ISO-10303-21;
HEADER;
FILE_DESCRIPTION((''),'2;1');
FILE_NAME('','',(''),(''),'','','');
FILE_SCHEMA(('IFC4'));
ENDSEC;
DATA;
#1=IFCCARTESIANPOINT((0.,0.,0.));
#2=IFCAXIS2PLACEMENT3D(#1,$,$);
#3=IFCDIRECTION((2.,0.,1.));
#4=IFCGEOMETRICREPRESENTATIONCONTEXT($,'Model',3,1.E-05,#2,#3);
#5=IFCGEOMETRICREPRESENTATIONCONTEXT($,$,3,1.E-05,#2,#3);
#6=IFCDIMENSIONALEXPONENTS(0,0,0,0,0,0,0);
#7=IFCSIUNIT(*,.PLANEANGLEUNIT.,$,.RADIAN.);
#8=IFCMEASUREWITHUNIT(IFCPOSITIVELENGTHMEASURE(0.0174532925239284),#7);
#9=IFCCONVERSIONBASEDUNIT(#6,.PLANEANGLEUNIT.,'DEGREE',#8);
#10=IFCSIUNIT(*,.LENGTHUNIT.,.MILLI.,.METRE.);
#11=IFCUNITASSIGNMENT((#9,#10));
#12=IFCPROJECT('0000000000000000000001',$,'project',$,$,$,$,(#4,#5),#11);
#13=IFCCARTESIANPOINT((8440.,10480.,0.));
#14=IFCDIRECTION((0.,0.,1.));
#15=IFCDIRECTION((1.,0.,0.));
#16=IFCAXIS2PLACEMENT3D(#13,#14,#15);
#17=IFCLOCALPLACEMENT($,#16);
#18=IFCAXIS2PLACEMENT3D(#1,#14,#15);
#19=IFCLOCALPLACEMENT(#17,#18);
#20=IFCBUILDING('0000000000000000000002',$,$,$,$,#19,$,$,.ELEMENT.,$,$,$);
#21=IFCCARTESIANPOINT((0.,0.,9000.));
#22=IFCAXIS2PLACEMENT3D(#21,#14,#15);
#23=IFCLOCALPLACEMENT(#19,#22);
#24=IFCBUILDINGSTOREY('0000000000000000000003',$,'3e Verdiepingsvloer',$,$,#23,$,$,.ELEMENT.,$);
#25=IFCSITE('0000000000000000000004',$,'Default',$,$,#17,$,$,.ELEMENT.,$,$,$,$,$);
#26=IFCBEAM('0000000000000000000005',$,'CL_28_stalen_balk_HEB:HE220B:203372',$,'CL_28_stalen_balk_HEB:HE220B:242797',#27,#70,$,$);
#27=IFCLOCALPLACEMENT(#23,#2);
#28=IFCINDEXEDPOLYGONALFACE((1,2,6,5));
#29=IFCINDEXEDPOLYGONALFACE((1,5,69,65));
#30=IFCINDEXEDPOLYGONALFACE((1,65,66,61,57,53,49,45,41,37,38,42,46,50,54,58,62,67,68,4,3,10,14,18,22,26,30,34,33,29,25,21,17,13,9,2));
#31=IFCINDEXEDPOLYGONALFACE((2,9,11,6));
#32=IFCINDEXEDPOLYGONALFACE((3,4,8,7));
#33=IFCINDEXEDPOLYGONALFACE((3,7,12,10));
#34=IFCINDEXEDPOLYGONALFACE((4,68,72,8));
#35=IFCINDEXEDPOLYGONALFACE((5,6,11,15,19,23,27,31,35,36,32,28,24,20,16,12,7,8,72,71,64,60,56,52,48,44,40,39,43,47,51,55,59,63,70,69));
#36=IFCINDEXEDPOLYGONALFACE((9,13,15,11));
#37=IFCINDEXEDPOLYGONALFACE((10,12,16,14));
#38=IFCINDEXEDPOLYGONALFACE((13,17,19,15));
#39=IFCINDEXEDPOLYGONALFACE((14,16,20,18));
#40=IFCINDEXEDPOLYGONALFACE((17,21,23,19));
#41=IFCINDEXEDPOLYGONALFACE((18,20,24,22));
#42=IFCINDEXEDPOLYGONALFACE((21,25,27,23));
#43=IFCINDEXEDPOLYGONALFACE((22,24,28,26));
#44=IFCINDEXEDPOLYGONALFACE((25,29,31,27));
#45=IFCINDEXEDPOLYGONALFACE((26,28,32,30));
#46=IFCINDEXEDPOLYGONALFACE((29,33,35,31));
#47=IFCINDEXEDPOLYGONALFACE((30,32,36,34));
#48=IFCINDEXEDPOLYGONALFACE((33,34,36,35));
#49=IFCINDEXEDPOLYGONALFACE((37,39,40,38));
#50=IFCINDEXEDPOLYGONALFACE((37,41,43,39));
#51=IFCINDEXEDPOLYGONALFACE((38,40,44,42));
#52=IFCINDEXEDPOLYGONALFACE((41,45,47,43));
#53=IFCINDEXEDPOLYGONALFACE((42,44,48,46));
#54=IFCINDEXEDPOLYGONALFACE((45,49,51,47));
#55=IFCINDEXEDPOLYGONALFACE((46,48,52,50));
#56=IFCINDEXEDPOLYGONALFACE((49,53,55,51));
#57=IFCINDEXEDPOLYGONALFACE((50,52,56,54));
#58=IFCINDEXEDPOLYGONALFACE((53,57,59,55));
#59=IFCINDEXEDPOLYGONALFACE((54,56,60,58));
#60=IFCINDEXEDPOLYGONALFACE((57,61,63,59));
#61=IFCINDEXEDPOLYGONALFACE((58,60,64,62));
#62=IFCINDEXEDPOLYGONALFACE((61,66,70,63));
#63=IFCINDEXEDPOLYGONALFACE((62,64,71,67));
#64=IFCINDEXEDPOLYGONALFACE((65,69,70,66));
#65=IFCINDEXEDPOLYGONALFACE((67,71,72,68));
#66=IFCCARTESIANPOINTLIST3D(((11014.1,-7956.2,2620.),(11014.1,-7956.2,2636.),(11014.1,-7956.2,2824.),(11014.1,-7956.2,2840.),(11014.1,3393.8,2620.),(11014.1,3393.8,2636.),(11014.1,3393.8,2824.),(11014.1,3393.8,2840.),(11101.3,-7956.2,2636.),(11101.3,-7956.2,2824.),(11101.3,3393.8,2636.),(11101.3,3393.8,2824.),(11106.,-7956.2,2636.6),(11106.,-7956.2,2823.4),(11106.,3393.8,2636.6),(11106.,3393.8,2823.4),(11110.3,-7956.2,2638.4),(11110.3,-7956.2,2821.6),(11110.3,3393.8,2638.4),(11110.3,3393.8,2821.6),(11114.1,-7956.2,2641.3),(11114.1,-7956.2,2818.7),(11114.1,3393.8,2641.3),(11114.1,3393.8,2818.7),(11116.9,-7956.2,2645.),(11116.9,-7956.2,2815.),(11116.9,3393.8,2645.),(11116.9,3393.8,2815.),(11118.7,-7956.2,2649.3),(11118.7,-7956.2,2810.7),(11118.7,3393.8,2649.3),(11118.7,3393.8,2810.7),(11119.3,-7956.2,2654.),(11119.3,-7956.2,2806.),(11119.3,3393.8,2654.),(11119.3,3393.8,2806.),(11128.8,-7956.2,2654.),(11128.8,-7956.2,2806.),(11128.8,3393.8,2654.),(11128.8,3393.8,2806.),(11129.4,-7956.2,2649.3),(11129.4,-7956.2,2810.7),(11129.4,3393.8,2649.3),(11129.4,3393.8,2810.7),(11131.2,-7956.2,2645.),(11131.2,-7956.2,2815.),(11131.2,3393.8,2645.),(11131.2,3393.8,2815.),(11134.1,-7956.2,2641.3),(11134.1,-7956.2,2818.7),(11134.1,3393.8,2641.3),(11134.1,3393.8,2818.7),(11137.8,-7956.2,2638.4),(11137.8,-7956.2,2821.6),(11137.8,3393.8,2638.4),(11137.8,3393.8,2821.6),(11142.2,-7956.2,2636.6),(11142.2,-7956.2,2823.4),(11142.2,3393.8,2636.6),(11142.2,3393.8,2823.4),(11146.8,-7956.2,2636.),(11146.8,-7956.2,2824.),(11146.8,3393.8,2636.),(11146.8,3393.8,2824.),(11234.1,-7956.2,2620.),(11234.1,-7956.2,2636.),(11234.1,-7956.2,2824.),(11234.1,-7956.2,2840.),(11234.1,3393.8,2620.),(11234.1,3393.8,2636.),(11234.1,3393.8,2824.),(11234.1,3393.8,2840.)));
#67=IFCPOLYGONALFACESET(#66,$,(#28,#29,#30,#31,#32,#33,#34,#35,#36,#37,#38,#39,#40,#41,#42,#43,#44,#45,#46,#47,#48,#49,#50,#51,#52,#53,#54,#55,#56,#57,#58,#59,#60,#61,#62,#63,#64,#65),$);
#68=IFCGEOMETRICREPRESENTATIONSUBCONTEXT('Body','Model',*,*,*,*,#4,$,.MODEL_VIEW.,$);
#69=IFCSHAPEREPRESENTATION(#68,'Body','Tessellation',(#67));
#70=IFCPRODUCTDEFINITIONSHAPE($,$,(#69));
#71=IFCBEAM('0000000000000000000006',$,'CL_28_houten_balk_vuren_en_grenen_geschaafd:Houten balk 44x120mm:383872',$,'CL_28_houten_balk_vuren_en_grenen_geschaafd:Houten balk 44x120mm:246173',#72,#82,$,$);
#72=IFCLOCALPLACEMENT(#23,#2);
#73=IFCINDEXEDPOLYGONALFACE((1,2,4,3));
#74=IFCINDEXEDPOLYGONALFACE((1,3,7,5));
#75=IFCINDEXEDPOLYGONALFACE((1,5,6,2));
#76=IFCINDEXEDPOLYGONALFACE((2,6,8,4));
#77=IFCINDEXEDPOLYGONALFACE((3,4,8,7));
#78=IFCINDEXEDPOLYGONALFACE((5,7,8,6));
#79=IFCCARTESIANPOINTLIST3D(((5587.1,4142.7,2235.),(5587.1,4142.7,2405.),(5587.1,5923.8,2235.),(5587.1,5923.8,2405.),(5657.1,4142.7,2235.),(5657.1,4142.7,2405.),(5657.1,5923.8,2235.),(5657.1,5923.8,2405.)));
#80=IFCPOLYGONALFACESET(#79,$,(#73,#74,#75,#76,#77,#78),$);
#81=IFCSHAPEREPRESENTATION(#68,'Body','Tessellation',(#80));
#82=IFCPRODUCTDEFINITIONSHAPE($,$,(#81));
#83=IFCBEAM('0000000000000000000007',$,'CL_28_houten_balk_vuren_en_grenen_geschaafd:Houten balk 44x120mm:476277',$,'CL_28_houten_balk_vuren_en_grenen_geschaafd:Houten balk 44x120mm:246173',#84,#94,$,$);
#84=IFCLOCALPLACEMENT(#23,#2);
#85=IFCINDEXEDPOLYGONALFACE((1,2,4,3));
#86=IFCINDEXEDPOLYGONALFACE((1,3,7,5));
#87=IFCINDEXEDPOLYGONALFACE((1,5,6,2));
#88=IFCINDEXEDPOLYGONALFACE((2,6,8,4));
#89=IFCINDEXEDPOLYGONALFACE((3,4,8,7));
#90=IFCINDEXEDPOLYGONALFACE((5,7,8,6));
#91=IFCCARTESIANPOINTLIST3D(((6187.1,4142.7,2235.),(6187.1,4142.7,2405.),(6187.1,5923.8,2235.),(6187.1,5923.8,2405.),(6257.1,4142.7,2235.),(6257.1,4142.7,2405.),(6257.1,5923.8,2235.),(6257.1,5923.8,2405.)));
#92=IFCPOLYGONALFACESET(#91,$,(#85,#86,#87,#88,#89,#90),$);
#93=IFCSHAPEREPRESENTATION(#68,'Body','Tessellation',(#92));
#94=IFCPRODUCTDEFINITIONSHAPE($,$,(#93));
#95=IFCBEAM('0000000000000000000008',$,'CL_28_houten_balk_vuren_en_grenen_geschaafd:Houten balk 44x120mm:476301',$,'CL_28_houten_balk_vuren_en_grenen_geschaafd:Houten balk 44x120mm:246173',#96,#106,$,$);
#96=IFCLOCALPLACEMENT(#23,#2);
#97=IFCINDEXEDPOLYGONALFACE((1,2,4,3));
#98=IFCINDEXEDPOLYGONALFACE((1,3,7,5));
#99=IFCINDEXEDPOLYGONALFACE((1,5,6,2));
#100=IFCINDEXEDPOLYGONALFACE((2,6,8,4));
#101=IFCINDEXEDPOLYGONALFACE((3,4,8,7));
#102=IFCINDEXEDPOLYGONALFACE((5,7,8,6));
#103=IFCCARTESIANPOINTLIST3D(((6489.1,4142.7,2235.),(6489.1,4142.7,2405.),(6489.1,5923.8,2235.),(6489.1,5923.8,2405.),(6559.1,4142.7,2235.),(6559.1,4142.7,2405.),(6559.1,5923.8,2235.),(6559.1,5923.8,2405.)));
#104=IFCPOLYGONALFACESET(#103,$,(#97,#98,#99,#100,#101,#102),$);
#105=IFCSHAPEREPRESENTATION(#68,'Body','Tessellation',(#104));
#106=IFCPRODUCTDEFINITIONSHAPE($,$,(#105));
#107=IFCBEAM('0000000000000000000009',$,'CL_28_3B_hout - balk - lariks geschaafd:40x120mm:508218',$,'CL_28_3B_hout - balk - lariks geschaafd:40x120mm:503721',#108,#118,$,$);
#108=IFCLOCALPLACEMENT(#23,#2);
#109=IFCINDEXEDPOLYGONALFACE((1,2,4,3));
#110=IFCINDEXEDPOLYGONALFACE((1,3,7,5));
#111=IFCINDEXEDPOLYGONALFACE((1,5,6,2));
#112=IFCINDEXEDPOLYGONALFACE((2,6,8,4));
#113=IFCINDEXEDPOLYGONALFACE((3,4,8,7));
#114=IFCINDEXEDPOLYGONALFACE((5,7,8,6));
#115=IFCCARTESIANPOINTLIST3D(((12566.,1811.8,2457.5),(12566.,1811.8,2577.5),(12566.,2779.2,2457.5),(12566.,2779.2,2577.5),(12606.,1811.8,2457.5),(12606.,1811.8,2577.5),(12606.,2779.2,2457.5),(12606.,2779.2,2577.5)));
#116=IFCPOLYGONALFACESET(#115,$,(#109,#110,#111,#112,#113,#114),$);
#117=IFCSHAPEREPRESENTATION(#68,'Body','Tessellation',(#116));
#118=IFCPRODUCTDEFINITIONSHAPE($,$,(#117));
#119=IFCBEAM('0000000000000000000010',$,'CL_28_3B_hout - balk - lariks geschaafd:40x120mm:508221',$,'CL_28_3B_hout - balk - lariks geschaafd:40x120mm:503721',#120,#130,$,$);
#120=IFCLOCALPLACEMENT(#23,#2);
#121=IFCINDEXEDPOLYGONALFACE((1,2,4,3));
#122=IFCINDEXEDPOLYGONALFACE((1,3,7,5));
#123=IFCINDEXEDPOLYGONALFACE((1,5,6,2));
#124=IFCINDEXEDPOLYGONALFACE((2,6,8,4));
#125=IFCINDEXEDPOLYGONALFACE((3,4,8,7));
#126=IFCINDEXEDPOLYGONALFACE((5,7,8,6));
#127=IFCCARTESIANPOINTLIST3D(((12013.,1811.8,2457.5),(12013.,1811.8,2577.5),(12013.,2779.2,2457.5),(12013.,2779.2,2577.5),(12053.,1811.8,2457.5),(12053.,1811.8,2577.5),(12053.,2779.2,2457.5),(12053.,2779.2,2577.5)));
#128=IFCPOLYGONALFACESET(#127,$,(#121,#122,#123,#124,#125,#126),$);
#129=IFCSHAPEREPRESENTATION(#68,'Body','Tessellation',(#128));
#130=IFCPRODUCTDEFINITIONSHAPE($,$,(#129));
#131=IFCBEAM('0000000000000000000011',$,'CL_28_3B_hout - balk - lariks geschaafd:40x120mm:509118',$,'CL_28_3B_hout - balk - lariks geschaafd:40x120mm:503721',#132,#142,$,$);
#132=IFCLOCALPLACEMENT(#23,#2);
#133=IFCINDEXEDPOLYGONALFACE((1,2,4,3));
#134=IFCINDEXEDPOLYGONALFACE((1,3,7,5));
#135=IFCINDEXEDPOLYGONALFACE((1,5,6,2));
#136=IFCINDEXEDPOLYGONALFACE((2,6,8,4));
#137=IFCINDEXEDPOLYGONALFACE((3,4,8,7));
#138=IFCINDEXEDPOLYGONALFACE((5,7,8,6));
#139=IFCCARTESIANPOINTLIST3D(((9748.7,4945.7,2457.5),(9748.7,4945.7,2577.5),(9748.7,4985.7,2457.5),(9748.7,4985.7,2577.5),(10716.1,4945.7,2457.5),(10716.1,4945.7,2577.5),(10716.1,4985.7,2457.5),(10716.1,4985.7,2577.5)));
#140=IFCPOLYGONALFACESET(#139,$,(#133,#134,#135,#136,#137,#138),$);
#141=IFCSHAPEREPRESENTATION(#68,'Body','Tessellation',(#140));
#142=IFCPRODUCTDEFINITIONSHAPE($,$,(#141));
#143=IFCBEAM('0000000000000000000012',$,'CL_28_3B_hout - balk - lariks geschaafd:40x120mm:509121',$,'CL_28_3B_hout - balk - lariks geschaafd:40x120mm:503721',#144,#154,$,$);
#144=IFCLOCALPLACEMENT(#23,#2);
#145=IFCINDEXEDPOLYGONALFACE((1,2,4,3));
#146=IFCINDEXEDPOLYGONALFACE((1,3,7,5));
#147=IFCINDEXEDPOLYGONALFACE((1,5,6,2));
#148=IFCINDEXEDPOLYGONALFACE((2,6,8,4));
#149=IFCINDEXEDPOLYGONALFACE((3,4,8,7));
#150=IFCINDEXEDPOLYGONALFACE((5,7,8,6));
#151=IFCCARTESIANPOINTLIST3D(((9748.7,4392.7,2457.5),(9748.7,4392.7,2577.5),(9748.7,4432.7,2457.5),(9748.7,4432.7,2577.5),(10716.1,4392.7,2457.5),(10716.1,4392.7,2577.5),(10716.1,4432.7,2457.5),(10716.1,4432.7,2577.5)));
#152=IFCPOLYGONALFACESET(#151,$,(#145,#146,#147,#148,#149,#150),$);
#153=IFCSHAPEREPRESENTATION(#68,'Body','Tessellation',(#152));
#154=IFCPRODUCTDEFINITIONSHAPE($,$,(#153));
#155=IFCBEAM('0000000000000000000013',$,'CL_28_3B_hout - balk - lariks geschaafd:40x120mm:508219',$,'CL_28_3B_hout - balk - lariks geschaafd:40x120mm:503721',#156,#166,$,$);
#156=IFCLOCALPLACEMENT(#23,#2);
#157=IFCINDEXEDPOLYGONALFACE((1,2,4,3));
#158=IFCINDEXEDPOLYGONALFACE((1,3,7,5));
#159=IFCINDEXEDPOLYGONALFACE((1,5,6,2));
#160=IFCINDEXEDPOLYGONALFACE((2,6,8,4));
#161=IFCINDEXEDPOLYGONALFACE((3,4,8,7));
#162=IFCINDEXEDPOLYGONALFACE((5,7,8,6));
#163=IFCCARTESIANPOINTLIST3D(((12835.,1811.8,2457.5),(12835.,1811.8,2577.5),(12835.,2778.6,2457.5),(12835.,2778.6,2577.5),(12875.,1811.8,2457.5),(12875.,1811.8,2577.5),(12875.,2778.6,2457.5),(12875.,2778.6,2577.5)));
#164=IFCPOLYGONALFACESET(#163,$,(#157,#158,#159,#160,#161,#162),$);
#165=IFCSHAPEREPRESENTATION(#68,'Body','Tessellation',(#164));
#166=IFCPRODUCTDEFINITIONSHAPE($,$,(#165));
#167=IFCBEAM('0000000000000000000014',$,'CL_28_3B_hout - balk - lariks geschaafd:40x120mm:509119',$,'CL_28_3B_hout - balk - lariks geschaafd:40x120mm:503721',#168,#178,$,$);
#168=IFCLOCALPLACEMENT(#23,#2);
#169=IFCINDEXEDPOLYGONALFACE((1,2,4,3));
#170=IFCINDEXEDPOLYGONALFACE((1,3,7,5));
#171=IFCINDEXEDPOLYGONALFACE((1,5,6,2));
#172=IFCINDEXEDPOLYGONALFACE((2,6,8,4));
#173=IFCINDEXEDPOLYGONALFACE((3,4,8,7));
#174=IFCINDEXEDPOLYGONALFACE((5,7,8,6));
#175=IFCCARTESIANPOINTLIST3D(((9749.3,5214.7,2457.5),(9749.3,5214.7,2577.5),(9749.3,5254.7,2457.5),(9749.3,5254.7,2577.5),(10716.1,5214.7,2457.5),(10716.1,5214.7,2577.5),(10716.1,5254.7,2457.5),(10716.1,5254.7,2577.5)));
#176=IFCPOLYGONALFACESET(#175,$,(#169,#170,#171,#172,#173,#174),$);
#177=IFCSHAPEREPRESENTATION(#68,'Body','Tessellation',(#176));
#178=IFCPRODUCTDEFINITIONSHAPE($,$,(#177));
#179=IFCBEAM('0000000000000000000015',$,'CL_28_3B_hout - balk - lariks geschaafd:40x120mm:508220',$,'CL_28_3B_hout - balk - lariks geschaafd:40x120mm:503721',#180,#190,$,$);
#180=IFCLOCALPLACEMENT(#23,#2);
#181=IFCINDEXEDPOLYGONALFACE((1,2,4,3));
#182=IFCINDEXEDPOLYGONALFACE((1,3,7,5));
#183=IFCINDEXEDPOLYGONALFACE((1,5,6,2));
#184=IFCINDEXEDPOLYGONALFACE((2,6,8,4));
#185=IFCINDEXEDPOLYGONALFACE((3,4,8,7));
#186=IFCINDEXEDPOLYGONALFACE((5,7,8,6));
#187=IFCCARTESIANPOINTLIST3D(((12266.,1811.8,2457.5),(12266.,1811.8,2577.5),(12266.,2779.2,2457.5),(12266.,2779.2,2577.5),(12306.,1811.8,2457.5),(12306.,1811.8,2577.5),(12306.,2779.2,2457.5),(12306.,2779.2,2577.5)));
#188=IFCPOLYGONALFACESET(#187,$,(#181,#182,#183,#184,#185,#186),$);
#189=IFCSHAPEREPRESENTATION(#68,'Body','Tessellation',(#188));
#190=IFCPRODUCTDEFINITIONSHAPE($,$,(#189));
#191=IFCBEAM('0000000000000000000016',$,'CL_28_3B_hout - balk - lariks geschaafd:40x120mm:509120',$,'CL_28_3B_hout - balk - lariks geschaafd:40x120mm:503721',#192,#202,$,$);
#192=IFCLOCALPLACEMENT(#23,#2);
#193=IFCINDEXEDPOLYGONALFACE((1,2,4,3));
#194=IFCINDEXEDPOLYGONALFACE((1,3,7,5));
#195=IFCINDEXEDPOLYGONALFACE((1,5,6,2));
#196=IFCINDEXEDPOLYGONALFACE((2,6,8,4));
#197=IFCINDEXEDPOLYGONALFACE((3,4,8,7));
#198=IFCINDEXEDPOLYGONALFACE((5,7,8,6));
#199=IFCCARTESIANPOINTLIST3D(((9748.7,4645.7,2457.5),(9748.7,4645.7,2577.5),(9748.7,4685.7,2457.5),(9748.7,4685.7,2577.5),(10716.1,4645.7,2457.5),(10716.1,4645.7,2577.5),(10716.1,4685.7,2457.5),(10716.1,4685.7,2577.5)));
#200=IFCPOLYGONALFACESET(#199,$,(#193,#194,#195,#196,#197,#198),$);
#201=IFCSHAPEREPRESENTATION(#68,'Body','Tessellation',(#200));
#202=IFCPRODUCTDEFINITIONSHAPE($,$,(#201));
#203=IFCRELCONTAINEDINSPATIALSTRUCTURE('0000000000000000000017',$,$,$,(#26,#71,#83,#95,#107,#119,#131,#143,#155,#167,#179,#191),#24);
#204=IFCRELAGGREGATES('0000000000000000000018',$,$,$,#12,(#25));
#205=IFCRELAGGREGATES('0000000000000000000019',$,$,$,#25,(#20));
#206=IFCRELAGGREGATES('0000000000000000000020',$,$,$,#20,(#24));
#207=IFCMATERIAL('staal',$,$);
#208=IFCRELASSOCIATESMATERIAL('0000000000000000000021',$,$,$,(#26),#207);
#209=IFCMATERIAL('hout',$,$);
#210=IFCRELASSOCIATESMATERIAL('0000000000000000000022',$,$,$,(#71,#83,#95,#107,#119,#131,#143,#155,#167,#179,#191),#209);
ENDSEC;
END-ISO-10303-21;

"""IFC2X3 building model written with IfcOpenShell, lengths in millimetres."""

from ifc_helpers import new_model, entity, si_unit, converted_unit, direction, frame, frame_2d, origin, origin_with_axes, origin_2d_with_axis, place, context, subcontext, project, spatial, rectangle, i_section, extrude, source, transform, mapped, material, element, save


model = new_model("IFC2X3")

# Units and contexts
model_context = context("Model", 3, precision=1e-05, world=origin(), true_north=direction((2.0, 0.0, 1.0)))
context_of_model = context(None, 3, precision=1e-05, world=origin(), true_north=direction((2.0, 0.0, 1.0)))
body_context = subcontext(model_context, "Body", "Model", "MODEL_VIEW")
ifc_project = project(units=[converted_unit("PLANEANGLEUNIT", "DEGREE", entity("IfcPositiveLengthMeasure", 0.0174532925239284), si_unit("PLANEANGLEUNIT", "RADIAN"), dimensions=[0, 0, 0, 0, 0, 0, 0]), si_unit("LENGTHUNIT", "METRE", prefix="MILLI")], contexts=[model_context, context_of_model])

# Site, building, storey
site_placement = place(None, frame((8440.0, 10480.0, 0.0), z_axis=(0.0, 0.0, 1.0), x_axis=(1.0, 0.0, 0.0)))
site = spatial("IfcSite", under=ifc_project, at=site_placement, Name="Default", CompositionType="ELEMENT")
building_placement = place(site_placement, origin_with_axes())
building = spatial("IfcBuilding", under=site, at=building_placement, CompositionType="ELEMENT")
storey_placement = place(building_placement, frame((0.0, 0.0, 9000.0), z_axis=(0.0, 0.0, 1.0), x_axis=(1.0, 0.0, 0.0)))
storey = spatial("IfcBuildingStorey", under=building, at=storey_placement, Name="3e Verdiepingsvloer", CompositionType="ELEMENT")

# Beams
ifc_material_1 = material(Name="staal")
shared_shape_1 = source(origin(), body_context, "Body", "SweptSolid", [
    extrude(i_section(OverallWidth=220.0, OverallDepth=220.0, WebThickness=9.5, FlangeThickness=16.0, FilletRadius=18.0, at=frame_2d((0.0, 0.0), x_axis=(0.0, 1.0))), frame((0.0, 0.0, -110.0), z_axis=(1.0, 0.0, 0.0), x_axis=(0.0, 0.0, -1.0)), (0.0, 0.0, 1.0), 11350.0),
])
beam_1_placement = place(storey_placement, frame((11124.1, -7956.2, 2840.0), z_axis=(0.0, 0.0, 1.0), x_axis=(0.0, 1.0, 0.0)))
element("IfcBeam", 1, at=beam_1_placement, inside=storey, material=ifc_material_1, Name="CL_28_stalen_balk_HEB:HE220B:203372", ObjectType="CL_28_stalen_balk_HEB:HE220B:242797", context=body_context, shape_type="MappedRepresentation", body=[
    mapped(shared_shape_1, transform((0.0, 0.0, 0.0))),
])
ifc_material_2 = material(Name="hout")
shared_shape_2 = source(origin(), body_context, "Body", "SweptSolid", [
    extrude(rectangle(XDim=170.0, YDim=70.0, at=frame_2d((0.0, 0.0), x_axis=(1.0, 0.0))), frame((0.0, 0.0, -85.0), z_axis=(1.0, 0.0, 0.0), x_axis=(0.0, 0.0, -1.0)), (0.0, 0.0, 1.0), 1781.1),
])
for number, where, z_axis, x_axis, name in (
    (2, (5622.1, 4142.7, 2405.0), (0.0, 0.0, 1.0), (0.0, 1.0, 0.0), "CL_28_houten_balk_vuren_en_grenen_geschaafd:Houten balk 44x120mm:383872"),
    (3, (6222.1, 4142.7, 2405.0), (0.0, 0.0, 1.0), (0.0, 1.0, 0.0), "CL_28_houten_balk_vuren_en_grenen_geschaafd:Houten balk 44x120mm:476277"),
    (4, (6524.1, 4142.7, 2405.0), (0.0, 0.0, 1.0), (0.0, 1.0, 0.0), "CL_28_houten_balk_vuren_en_grenen_geschaafd:Houten balk 44x120mm:476301"),
):
    element("IfcBeam", number, at=place(storey_placement, frame(where, z_axis=z_axis, x_axis=x_axis)), inside=storey, material=ifc_material_2, Name=name, ObjectType="CL_28_houten_balk_vuren_en_grenen_geschaafd:Houten balk 44x120mm:246173", context=body_context, shape_type="MappedRepresentation", body=[
        mapped(shared_shape_2, transform((0.0, 0.0, 0.0))),
    ])
shared_shape_3 = source(origin(), body_context, "Body", "SweptSolid", [
    extrude(rectangle(XDim=120.0, YDim=40.0, at=origin_2d_with_axis()), frame((68.6, 0.0, -60.0), z_axis=(1.0, 0.0, 0.0), x_axis=(0.0, 0.0, -1.0)), (0.0, 0.0, 1.0), 967.4),
])
for number, where, z_axis, x_axis, name in (
    (5, (12586.0, 2847.8, 2577.5), (0.0, 0.0, 1.0), (0.0, -1.0, 0.0), "CL_28_3B_hout - balk - lariks geschaafd:40x120mm:508218"),
    (6, (12033.0, 2847.8, 2577.5), (0.0, 0.0, 1.0), (0.0, -1.0, 0.0), "CL_28_3B_hout - balk - lariks geschaafd:40x120mm:508221"),
    (7, (9680.1, 4965.7, 2577.5), (0.0, 0.0, 1.0), (1.0, 0.0, 0.0), "CL_28_3B_hout - balk - lariks geschaafd:40x120mm:509118"),
    (8, (9680.1, 4412.7, 2577.5), (0.0, 0.0, 1.0), (1.0, 0.0, 0.0), "CL_28_3B_hout - balk - lariks geschaafd:40x120mm:509121"),
):
    element("IfcBeam", number, at=place(storey_placement, frame(where, z_axis=z_axis, x_axis=x_axis)), inside=storey, material=ifc_material_2, Name=name, ObjectType="CL_28_3B_hout - balk - lariks geschaafd:40x120mm:503721", context=body_context, shape_type="MappedRepresentation", body=[
        mapped(shared_shape_3, transform((0.0, 0.0, 0.0))),
    ])
shared_shape_4 = source(origin(), body_context, "Body", "SweptSolid", [
    extrude(rectangle(XDim=120.0, YDim=40.0, at=origin_2d_with_axis()), frame((109.2, 0.0, -60.0), z_axis=(1.0, 0.0, 0.0), x_axis=(0.0, 0.0, -1.0)), (0.0, 0.0, 1.0), 966.8),
])
for number, where, z_axis, x_axis, name in (
    (9, (12855.0, 2887.8, 2577.5), (0.0, 0.0, 1.0), (0.0, -1.0, 0.0), "CL_28_3B_hout - balk - lariks geschaafd:40x120mm:508219"),
    (10, (9640.1, 5234.7, 2577.5), (0.0, 0.0, 1.0), (1.0, 0.0, 0.0), "CL_28_3B_hout - balk - lariks geschaafd:40x120mm:509119"),
):
    element("IfcBeam", number, at=place(storey_placement, frame(where, z_axis=z_axis, x_axis=x_axis)), inside=storey, material=ifc_material_2, Name=name, ObjectType="CL_28_3B_hout - balk - lariks geschaafd:40x120mm:503721", context=body_context, shape_type="MappedRepresentation", body=[
        mapped(shared_shape_4, transform((0.0, 0.0, 0.0))),
    ])
shared_shape_5 = source(origin(), body_context, "Body", "SweptSolid", [
    extrude(rectangle(XDim=120.0, YDim=40.0, at=origin_2d_with_axis()), frame((73.6, 0.0, -60.0), z_axis=(1.0, 0.0, 0.0), x_axis=(0.0, 0.0, -1.0)), (0.0, 0.0, 1.0), 967.4),
])
for number, where, z_axis, x_axis, name in (
    (11, (12286.0, 2852.8, 2577.5), (0.0, 0.0, 1.0), (0.0, -1.0, 0.0), "CL_28_3B_hout - balk - lariks geschaafd:40x120mm:508220"),
    (12, (9675.1, 4665.7, 2577.5), (0.0, 0.0, 1.0), (1.0, 0.0, 0.0), "CL_28_3B_hout - balk - lariks geschaafd:40x120mm:509120"),
):
    element("IfcBeam", number, at=place(storey_placement, frame(where, z_axis=z_axis, x_axis=x_axis)), inside=storey, material=ifc_material_2, Name=name, ObjectType="CL_28_3B_hout - balk - lariks geschaafd:40x120mm:503721", context=body_context, shape_type="MappedRepresentation", body=[
        mapped(shared_shape_5, transform((0.0, 0.0, 0.0))),
    ])

save(model, "model.ifc")
